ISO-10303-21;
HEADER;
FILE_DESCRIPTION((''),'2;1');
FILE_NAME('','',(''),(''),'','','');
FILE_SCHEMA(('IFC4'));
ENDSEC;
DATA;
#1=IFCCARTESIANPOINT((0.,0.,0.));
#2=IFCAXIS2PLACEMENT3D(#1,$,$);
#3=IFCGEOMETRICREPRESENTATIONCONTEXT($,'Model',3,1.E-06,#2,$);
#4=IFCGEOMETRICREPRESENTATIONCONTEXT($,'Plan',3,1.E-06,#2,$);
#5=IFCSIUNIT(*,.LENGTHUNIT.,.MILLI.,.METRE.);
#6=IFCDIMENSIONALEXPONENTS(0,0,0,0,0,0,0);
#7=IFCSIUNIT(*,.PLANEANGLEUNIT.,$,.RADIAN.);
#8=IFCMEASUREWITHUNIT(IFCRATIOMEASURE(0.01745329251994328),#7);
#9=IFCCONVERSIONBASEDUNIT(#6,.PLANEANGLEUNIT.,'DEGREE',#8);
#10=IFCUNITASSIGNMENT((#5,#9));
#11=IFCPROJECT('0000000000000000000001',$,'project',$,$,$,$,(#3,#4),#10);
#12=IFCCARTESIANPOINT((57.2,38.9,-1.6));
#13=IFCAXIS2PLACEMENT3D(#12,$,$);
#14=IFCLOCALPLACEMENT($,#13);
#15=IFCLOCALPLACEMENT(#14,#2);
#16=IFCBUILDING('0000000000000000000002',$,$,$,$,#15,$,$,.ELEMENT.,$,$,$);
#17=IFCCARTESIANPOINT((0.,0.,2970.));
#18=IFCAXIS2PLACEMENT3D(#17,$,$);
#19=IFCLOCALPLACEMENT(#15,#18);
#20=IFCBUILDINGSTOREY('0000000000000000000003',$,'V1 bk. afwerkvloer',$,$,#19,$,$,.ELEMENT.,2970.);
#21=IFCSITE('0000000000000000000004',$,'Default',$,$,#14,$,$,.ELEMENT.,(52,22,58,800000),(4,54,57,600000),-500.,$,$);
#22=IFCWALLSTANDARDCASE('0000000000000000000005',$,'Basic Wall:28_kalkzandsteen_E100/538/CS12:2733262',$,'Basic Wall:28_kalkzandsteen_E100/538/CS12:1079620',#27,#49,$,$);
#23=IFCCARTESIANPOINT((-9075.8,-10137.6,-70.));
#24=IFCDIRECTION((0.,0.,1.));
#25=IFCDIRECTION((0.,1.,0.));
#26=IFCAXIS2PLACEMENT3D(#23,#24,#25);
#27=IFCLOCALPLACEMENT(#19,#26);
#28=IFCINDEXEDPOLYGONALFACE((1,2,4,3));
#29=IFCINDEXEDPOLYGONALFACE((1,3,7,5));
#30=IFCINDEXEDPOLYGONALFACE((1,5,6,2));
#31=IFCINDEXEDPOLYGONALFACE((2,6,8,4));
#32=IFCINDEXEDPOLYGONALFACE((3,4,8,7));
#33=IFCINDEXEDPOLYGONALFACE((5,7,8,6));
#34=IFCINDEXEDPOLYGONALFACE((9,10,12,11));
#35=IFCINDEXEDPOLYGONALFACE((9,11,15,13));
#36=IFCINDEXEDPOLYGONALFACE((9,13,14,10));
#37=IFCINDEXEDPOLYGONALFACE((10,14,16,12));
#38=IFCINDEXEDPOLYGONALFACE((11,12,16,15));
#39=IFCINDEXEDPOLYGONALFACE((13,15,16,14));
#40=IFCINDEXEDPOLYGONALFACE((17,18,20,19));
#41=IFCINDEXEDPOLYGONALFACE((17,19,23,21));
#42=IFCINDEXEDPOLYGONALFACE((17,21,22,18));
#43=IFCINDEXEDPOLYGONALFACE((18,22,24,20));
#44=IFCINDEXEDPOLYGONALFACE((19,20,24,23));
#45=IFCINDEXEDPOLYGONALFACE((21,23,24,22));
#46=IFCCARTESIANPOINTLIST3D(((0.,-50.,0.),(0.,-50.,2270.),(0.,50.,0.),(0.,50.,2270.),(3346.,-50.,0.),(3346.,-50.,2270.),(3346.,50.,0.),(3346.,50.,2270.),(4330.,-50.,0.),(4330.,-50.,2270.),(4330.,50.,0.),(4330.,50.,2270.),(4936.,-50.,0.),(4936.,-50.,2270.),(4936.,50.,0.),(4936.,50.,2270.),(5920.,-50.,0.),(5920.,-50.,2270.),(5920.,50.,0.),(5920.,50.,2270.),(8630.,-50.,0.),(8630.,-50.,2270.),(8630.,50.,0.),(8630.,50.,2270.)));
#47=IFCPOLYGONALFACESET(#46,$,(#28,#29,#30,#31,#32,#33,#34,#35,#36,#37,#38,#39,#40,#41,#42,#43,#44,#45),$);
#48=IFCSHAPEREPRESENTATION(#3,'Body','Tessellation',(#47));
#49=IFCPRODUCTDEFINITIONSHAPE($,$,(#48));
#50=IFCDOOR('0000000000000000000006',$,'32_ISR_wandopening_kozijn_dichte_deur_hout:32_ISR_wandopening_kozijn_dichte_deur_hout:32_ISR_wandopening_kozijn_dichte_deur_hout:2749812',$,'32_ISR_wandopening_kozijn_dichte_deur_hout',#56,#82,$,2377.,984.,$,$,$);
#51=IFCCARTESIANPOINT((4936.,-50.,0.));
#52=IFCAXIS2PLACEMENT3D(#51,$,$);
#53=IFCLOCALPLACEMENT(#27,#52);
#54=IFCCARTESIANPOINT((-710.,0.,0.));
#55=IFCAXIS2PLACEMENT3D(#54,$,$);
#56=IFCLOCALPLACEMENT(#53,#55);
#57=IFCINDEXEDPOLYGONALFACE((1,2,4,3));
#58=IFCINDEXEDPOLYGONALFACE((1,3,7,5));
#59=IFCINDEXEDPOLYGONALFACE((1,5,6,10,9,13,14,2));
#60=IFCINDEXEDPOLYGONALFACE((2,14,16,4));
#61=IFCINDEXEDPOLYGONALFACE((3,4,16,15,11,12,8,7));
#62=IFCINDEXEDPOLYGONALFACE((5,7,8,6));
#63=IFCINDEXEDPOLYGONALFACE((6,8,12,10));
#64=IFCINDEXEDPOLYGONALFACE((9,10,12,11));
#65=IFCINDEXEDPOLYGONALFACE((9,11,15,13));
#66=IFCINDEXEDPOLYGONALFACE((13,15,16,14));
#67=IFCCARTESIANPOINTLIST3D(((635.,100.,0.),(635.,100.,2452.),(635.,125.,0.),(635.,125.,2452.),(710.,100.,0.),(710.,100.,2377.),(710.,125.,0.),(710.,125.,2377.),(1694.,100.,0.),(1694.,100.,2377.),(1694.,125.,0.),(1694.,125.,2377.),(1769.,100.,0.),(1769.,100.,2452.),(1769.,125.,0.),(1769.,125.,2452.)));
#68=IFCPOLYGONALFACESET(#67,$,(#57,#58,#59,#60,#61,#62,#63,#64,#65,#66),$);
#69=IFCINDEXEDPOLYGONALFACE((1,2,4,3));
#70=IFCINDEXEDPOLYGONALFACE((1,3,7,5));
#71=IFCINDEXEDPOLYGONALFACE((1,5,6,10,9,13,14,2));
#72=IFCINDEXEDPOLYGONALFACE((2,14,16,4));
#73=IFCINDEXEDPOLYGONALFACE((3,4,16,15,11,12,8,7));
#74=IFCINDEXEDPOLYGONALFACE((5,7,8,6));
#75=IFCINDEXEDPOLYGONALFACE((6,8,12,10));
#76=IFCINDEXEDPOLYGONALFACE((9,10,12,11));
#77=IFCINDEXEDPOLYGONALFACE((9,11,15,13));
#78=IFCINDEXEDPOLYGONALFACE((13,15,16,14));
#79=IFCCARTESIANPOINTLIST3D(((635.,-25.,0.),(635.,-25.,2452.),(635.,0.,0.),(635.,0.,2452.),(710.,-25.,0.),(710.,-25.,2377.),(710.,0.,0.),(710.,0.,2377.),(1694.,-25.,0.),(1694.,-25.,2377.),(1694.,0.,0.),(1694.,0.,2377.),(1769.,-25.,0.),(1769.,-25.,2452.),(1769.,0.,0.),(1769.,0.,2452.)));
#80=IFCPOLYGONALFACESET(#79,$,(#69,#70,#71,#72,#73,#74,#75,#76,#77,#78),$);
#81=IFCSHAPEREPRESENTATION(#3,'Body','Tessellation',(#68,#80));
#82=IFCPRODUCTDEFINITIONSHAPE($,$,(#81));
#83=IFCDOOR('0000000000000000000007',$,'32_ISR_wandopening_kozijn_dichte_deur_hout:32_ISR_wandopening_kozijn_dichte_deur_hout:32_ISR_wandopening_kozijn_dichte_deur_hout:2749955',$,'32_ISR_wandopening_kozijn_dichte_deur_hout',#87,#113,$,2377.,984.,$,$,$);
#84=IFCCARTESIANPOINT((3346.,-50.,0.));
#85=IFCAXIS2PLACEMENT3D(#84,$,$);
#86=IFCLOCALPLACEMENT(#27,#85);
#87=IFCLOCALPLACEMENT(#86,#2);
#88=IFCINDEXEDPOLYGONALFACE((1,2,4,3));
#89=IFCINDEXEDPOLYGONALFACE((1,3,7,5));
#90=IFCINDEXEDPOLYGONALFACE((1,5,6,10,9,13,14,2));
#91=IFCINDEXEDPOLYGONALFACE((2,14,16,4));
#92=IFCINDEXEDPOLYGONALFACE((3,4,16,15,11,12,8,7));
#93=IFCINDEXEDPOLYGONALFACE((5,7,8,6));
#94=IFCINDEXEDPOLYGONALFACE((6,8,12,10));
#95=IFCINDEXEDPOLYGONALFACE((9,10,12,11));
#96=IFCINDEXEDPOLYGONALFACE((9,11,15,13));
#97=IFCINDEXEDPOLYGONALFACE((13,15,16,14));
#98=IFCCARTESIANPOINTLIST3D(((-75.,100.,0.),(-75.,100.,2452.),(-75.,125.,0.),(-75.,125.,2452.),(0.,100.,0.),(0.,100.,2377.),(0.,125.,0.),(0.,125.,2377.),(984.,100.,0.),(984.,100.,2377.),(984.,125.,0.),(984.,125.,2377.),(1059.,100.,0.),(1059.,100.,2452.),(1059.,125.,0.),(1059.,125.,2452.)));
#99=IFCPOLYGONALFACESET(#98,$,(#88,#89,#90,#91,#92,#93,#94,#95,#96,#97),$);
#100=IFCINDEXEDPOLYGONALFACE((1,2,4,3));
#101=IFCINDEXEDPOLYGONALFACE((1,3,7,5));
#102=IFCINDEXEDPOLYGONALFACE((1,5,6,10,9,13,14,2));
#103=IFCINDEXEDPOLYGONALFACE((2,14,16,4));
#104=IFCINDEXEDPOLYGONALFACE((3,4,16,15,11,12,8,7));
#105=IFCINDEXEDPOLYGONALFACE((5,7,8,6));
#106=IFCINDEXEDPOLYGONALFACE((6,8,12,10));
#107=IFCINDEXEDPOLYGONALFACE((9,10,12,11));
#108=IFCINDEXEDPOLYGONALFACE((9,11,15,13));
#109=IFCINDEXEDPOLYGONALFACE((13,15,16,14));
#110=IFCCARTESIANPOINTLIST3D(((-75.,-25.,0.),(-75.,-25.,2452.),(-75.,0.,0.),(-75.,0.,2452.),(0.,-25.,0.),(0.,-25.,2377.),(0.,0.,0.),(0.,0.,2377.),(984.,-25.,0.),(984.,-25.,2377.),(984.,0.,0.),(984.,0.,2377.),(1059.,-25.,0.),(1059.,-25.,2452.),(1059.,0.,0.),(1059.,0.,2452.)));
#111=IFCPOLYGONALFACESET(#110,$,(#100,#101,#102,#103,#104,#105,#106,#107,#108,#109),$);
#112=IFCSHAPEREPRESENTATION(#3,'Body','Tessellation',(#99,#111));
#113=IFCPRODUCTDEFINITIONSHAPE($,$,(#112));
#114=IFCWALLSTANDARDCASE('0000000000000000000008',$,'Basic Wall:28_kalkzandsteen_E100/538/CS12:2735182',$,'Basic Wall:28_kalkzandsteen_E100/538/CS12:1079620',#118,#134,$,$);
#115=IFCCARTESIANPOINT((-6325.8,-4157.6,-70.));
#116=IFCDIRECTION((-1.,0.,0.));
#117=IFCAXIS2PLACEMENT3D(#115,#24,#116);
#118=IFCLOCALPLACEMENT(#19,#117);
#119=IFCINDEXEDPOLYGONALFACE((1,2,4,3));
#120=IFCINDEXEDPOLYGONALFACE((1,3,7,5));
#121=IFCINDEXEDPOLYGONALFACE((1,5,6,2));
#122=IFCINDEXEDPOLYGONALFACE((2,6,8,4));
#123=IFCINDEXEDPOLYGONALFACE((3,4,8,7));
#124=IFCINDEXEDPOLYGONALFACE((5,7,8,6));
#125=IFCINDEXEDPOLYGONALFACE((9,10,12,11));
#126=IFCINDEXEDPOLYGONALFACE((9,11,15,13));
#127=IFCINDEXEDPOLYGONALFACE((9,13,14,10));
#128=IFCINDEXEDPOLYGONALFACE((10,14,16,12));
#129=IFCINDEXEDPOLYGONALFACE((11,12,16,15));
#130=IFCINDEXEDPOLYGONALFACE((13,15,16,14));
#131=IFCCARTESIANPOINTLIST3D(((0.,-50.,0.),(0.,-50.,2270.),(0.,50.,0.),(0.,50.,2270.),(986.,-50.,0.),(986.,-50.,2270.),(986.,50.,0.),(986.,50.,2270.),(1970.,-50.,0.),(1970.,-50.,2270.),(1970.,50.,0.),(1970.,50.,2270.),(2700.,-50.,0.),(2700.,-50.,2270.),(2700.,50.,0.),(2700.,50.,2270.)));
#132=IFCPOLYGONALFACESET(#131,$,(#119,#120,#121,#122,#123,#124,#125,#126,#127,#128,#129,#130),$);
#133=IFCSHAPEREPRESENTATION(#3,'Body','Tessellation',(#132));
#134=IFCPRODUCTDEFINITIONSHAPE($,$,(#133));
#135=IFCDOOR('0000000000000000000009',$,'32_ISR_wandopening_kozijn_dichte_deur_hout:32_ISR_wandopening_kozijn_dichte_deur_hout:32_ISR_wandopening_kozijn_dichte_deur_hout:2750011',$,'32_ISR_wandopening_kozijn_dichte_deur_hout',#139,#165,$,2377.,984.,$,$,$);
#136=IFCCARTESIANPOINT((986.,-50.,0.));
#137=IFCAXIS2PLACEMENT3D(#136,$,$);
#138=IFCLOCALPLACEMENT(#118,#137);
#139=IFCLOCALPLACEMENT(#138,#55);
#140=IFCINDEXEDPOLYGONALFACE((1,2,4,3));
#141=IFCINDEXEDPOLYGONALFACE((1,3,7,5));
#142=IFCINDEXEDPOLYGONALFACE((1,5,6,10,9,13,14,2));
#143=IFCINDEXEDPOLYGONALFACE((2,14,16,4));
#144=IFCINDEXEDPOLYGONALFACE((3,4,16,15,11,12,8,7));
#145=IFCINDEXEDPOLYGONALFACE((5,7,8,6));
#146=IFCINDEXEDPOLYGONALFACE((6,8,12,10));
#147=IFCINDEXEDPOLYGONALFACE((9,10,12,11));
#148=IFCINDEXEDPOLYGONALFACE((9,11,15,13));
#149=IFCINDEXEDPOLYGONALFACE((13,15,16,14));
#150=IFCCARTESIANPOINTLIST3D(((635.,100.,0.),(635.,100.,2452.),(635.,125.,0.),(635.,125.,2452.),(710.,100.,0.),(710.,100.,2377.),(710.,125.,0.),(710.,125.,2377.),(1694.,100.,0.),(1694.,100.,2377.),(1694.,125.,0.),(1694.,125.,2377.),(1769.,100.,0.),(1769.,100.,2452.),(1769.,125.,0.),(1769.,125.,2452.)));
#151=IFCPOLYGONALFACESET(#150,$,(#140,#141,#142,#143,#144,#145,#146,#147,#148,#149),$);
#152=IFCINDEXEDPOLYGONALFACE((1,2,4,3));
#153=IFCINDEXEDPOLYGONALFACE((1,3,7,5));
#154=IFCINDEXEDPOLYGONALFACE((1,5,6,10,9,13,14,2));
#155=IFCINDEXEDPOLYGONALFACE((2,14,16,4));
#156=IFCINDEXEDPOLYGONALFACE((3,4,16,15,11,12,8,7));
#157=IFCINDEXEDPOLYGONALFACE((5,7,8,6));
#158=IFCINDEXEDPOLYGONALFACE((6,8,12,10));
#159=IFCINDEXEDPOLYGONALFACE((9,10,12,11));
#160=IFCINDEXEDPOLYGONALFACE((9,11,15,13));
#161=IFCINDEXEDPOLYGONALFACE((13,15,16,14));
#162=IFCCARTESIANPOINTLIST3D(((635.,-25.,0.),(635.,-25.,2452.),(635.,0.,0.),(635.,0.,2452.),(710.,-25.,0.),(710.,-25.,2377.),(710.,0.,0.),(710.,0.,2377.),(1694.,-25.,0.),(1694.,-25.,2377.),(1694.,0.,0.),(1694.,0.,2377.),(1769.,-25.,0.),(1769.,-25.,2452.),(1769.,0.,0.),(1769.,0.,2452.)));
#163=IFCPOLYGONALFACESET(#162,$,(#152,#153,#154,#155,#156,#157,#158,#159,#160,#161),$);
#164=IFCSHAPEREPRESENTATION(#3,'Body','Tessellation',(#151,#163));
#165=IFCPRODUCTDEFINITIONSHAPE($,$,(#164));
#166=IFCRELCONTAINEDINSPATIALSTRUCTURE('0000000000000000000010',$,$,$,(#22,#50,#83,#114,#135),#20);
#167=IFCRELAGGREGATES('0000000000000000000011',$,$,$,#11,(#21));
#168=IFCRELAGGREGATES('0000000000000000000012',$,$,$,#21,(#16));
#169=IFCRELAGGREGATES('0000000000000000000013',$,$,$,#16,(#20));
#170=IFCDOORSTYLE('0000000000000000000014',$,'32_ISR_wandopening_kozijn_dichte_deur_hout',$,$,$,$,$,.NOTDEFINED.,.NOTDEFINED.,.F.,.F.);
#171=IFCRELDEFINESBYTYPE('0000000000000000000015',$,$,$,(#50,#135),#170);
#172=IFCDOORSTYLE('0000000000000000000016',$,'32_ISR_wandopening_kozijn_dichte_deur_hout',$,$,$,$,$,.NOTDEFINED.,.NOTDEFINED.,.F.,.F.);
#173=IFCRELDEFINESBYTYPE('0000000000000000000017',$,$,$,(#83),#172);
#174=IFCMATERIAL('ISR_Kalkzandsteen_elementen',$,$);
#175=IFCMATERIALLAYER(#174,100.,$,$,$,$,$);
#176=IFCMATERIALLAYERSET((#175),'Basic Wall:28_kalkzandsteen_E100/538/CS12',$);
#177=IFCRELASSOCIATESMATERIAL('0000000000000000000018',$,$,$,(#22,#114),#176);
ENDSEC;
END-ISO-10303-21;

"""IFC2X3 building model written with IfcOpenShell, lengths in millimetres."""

from ifc_helpers import new_model, entity, si_unit, converted_unit, frame, frame_2d, origin, place, context, project, spatial, polyline, rectangle, outline, extrude, source, transform, mapped, material, layer, layer_set, layer_usage, type_object, type_shapes, element, fill, save


model = new_model("IFC2X3")

# Units and contexts
model_context = context("Model", 3, precision=1e-06, world=origin())
plan_context = context("Plan", 3, precision=1e-06, world=origin())
ifc_project = project(units=[si_unit("LENGTHUNIT", "METRE", prefix="MILLI"), converted_unit("PLANEANGLEUNIT", "DEGREE", entity("IfcRatioMeasure", 0.01745329251994328), si_unit("PLANEANGLEUNIT", "RADIAN"), dimensions=[0, 0, 0, 0, 0, 0, 0])], contexts=[model_context, plan_context])

# Site, building, storey
site_placement = place(None, frame((57.2, 38.9, -1.6)))
site = spatial("IfcSite", under=ifc_project, at=site_placement, Name="Default", CompositionType="ELEMENT", RefLatitude=(52, 22, 58, 800000), RefLongitude=(4, 54, 57, 600000), RefElevation=-500.0)
building_placement = place(site_placement, origin())
building = spatial("IfcBuilding", under=site, at=building_placement, CompositionType="ELEMENT")
storey_placement = place(building_placement, frame((0.0, 0.0, 2970.0)))
storey = spatial("IfcBuildingStorey", under=building, at=storey_placement, Name="V1 bk. afwerkvloer", CompositionType="ELEMENT", Elevation=2970.0)

# Shared definitions
ifc_material_1 = material(Name="ISR_Kalkzandsteen_elementen")
ifc_layer_1 = layer(ifc_material_1, 100.0)
ifc_layer_set_1 = layer_set([ifc_layer_1], Name="Basic Wall:28_kalkzandsteen_E100/538/CS12")

# Wall, openings, doors
ifc_layer_usage_1 = layer_usage(ifc_layer_set_1, "AXIS2", "POSITIVE", -50.0)
wall_1_placement = place(storey_placement, frame((-9075.8, -10137.6, -70.0), z_axis=(0.0, 0.0, 1.0), x_axis=(0.0, 1.0, 0.0)))
wall_1 = element("IfcWallStandardCase", 1, at=wall_1_placement, inside=storey, material=ifc_layer_usage_1, Name="Basic Wall:28_kalkzandsteen_E100/538/CS12:2733262", ObjectType="Basic Wall:28_kalkzandsteen_E100/538/CS12:1079620", context=model_context, shape_type="SweptSolid", body=[
    extrude(rectangle(XDim=8630.0, YDim=100.0, at=frame_2d((4315.0, 0.0), x_axis=(-1.0, 0.0))), origin(), (0.0, 0.0, 1.0), 2270.0),
])
opening_1_placement = place(wall_1_placement, frame((4936.0, -50.0, 0.0)))
opening_1 = element("IfcOpeningElement", 2, at=opening_1_placement, cuts=wall_1, ObjectType="Opening", context=model_context, shape_type="SweptSolid", body=[
    extrude(rectangle(XDim=2377.0, YDim=984.0, at=frame_2d((1188.5, 492.0), x_axis=(1.0, 0.0))), frame((0.0, 0.0, 0.0), z_axis=(0.0, 1.0, 0.0), x_axis=(0.0, 0.0, 1.0)), (0.0, 0.0, 1.0), 100.0),
])
opening_2_placement = place(wall_1_placement, frame((3346.0, -50.0, 0.0)))
opening_2 = element("IfcOpeningElement", 3, at=opening_2_placement, cuts=wall_1, ObjectType="Opening", context=model_context, shape_type="SweptSolid", body=[
    extrude(rectangle(XDim=2377.0, YDim=984.0, at=frame_2d((1188.5, 492.0), x_axis=(1.0, 0.0))), frame((0.0, 0.0, 0.0), z_axis=(0.0, 1.0, 0.0), x_axis=(0.0, 0.0, 1.0)), (0.0, 0.0, 1.0), 100.0),
])
door_style_1 = type_object("IfcDoorStyle", Name="32_ISR_wandopening_kozijn_dichte_deur_hout", ConstructionType="NOTDEFINED", OperationType="NOTDEFINED", ParameterTakesPrecedence=False, Sizeable=False)
shared_shape_1 = source(origin(), model_context, "Body", "SweptSolid", [
    extrude(outline(polyline([(-1169.7, 492.0), (1207.2, 492.0), (1207.2, 567.0), (-1244.7, 567.0), (-1244.7, -567.0), (1207.2, -567.0), (1207.2, -492.0), (-1169.7, -492.0), (-1169.7, 492.0)])), frame((1202.0, 125.0, 1207.2), z_axis=(0.0, -1.0, 0.0), x_axis=(0.0, 0.0, -1.0)), (0.0, 0.0, 1.0), 25.0),
    extrude(outline(polyline([(-567.0, -1244.7), (567.0, -1244.7), (567.0, 1207.2), (492.0, 1207.2), (492.0, -1169.7), (-492.0, -1169.7), (-492.0, 1207.2), (-567.0, 1207.2), (-567.0, -1244.7)])), frame((1202.0, 0.0, 1207.2), z_axis=(0.0, -1.0, 0.0), x_axis=(-1.0, 0.0, 0.0)), (0.0, 0.0, 1.0), 25.0),
])
type_shapes(door_style_1, [shared_shape_1])
door_1_placement = place(opening_1_placement, frame((-710.0, 0.0, 0.0)))
door_1 = element("IfcDoor", 4, at=door_1_placement, inside=storey, type_object=door_style_1, Name="32_ISR_wandopening_kozijn_dichte_deur_hout:32_ISR_wandopening_kozijn_dichte_deur_hout:32_ISR_wandopening_kozijn_dichte_deur_hout:2749812", ObjectType="32_ISR_wandopening_kozijn_dichte_deur_hout", OverallHeight=2377.0, OverallWidth=984.0, context=model_context, shape_type="MappedRepresentation", body=[
    mapped(shared_shape_1, transform((0.0, 0.0, 0.0), scale=1.0)),
])
fill(opening_1, door_1)
door_style_2 = type_object("IfcDoorStyle", Name="32_ISR_wandopening_kozijn_dichte_deur_hout", ConstructionType="NOTDEFINED", OperationType="NOTDEFINED", ParameterTakesPrecedence=False, Sizeable=False)
shared_shape_2 = source(origin(), model_context, "Body", "SweptSolid", [
    extrude(outline(polyline([(-1169.7, 492.0), (1207.2, 492.0), (1207.2, 567.0), (-1244.7, 567.0), (-1244.7, -567.0), (1207.2, -567.0), (1207.2, -492.0), (-1169.7, -492.0), (-1169.7, 492.0)])), frame((492.0, 100.0, 1207.2), z_axis=(0.0, 1.0, 0.0), x_axis=(0.0, 0.0, -1.0)), (0.0, 0.0, 1.0), 25.0),
    extrude(outline(polyline([(-567.0, -1244.7), (567.0, -1244.7), (567.0, 1207.2), (492.0, 1207.2), (492.0, -1169.7), (-492.0, -1169.7), (-492.0, 1207.2), (-567.0, 1207.2), (-567.0, -1244.7)])), frame((492.0, -25.0, 1207.2), z_axis=(0.0, 1.0, 0.0), x_axis=(1.0, 0.0, 0.0)), (0.0, 0.0, 1.0), 25.0),
])
type_shapes(door_style_2, [shared_shape_2])
door_2_placement = place(opening_2_placement, origin())
door_2 = element("IfcDoor", 5, at=door_2_placement, inside=storey, type_object=door_style_2, Name="32_ISR_wandopening_kozijn_dichte_deur_hout:32_ISR_wandopening_kozijn_dichte_deur_hout:32_ISR_wandopening_kozijn_dichte_deur_hout:2749955", ObjectType="32_ISR_wandopening_kozijn_dichte_deur_hout", OverallHeight=2377.0, OverallWidth=984.0, context=model_context, shape_type="MappedRepresentation", body=[
    mapped(shared_shape_2, transform((0.0, 0.0, 0.0), scale=1.0)),
])
fill(opening_2, door_2)

# Wall, opening, door
ifc_layer_usage_2 = layer_usage(ifc_layer_set_1, "AXIS2", "NEGATIVE", 50.0)
wall_2_placement = place(storey_placement, frame((-6325.8, -4157.6, -70.0), z_axis=(0.0, 0.0, 1.0), x_axis=(-1.0, 0.0, 0.0)))
wall_2 = element("IfcWallStandardCase", 6, at=wall_2_placement, inside=storey, material=ifc_layer_usage_2, Name="Basic Wall:28_kalkzandsteen_E100/538/CS12:2735182", ObjectType="Basic Wall:28_kalkzandsteen_E100/538/CS12:1079620", context=model_context, shape_type="SweptSolid", body=[
    extrude(rectangle(XDim=2700.0, YDim=100.0, at=frame_2d((1350.0, 0.0), x_axis=(-1.0, 0.0))), origin(), (0.0, 0.0, 1.0), 2270.0),
])
opening_3_placement = place(wall_2_placement, frame((986.0, -50.0, 0.0)))
opening_3 = element("IfcOpeningElement", 7, at=opening_3_placement, cuts=wall_2, ObjectType="Opening", context=model_context, shape_type="SweptSolid", body=[
    extrude(rectangle(XDim=2377.0, YDim=984.0, at=frame_2d((1188.5, 492.0), x_axis=(1.0, 0.0))), frame((0.0, 0.0, 0.0), z_axis=(0.0, 1.0, 0.0), x_axis=(0.0, 0.0, 1.0)), (0.0, 0.0, 1.0), 100.0),
])
door_3_placement = place(opening_3_placement, frame((-710.0, 0.0, 0.0)))
door_3 = element("IfcDoor", 8, at=door_3_placement, inside=storey, type_object=door_style_1, Name="32_ISR_wandopening_kozijn_dichte_deur_hout:32_ISR_wandopening_kozijn_dichte_deur_hout:32_ISR_wandopening_kozijn_dichte_deur_hout:2750011", ObjectType="32_ISR_wandopening_kozijn_dichte_deur_hout", OverallHeight=2377.0, OverallWidth=984.0, context=model_context, shape_type="MappedRepresentation", body=[
    mapped(shared_shape_1, transform((0.0, 0.0, 0.0), scale=1.0)),
])
fill(opening_3, door_3)

save(model, "model.ifc")
